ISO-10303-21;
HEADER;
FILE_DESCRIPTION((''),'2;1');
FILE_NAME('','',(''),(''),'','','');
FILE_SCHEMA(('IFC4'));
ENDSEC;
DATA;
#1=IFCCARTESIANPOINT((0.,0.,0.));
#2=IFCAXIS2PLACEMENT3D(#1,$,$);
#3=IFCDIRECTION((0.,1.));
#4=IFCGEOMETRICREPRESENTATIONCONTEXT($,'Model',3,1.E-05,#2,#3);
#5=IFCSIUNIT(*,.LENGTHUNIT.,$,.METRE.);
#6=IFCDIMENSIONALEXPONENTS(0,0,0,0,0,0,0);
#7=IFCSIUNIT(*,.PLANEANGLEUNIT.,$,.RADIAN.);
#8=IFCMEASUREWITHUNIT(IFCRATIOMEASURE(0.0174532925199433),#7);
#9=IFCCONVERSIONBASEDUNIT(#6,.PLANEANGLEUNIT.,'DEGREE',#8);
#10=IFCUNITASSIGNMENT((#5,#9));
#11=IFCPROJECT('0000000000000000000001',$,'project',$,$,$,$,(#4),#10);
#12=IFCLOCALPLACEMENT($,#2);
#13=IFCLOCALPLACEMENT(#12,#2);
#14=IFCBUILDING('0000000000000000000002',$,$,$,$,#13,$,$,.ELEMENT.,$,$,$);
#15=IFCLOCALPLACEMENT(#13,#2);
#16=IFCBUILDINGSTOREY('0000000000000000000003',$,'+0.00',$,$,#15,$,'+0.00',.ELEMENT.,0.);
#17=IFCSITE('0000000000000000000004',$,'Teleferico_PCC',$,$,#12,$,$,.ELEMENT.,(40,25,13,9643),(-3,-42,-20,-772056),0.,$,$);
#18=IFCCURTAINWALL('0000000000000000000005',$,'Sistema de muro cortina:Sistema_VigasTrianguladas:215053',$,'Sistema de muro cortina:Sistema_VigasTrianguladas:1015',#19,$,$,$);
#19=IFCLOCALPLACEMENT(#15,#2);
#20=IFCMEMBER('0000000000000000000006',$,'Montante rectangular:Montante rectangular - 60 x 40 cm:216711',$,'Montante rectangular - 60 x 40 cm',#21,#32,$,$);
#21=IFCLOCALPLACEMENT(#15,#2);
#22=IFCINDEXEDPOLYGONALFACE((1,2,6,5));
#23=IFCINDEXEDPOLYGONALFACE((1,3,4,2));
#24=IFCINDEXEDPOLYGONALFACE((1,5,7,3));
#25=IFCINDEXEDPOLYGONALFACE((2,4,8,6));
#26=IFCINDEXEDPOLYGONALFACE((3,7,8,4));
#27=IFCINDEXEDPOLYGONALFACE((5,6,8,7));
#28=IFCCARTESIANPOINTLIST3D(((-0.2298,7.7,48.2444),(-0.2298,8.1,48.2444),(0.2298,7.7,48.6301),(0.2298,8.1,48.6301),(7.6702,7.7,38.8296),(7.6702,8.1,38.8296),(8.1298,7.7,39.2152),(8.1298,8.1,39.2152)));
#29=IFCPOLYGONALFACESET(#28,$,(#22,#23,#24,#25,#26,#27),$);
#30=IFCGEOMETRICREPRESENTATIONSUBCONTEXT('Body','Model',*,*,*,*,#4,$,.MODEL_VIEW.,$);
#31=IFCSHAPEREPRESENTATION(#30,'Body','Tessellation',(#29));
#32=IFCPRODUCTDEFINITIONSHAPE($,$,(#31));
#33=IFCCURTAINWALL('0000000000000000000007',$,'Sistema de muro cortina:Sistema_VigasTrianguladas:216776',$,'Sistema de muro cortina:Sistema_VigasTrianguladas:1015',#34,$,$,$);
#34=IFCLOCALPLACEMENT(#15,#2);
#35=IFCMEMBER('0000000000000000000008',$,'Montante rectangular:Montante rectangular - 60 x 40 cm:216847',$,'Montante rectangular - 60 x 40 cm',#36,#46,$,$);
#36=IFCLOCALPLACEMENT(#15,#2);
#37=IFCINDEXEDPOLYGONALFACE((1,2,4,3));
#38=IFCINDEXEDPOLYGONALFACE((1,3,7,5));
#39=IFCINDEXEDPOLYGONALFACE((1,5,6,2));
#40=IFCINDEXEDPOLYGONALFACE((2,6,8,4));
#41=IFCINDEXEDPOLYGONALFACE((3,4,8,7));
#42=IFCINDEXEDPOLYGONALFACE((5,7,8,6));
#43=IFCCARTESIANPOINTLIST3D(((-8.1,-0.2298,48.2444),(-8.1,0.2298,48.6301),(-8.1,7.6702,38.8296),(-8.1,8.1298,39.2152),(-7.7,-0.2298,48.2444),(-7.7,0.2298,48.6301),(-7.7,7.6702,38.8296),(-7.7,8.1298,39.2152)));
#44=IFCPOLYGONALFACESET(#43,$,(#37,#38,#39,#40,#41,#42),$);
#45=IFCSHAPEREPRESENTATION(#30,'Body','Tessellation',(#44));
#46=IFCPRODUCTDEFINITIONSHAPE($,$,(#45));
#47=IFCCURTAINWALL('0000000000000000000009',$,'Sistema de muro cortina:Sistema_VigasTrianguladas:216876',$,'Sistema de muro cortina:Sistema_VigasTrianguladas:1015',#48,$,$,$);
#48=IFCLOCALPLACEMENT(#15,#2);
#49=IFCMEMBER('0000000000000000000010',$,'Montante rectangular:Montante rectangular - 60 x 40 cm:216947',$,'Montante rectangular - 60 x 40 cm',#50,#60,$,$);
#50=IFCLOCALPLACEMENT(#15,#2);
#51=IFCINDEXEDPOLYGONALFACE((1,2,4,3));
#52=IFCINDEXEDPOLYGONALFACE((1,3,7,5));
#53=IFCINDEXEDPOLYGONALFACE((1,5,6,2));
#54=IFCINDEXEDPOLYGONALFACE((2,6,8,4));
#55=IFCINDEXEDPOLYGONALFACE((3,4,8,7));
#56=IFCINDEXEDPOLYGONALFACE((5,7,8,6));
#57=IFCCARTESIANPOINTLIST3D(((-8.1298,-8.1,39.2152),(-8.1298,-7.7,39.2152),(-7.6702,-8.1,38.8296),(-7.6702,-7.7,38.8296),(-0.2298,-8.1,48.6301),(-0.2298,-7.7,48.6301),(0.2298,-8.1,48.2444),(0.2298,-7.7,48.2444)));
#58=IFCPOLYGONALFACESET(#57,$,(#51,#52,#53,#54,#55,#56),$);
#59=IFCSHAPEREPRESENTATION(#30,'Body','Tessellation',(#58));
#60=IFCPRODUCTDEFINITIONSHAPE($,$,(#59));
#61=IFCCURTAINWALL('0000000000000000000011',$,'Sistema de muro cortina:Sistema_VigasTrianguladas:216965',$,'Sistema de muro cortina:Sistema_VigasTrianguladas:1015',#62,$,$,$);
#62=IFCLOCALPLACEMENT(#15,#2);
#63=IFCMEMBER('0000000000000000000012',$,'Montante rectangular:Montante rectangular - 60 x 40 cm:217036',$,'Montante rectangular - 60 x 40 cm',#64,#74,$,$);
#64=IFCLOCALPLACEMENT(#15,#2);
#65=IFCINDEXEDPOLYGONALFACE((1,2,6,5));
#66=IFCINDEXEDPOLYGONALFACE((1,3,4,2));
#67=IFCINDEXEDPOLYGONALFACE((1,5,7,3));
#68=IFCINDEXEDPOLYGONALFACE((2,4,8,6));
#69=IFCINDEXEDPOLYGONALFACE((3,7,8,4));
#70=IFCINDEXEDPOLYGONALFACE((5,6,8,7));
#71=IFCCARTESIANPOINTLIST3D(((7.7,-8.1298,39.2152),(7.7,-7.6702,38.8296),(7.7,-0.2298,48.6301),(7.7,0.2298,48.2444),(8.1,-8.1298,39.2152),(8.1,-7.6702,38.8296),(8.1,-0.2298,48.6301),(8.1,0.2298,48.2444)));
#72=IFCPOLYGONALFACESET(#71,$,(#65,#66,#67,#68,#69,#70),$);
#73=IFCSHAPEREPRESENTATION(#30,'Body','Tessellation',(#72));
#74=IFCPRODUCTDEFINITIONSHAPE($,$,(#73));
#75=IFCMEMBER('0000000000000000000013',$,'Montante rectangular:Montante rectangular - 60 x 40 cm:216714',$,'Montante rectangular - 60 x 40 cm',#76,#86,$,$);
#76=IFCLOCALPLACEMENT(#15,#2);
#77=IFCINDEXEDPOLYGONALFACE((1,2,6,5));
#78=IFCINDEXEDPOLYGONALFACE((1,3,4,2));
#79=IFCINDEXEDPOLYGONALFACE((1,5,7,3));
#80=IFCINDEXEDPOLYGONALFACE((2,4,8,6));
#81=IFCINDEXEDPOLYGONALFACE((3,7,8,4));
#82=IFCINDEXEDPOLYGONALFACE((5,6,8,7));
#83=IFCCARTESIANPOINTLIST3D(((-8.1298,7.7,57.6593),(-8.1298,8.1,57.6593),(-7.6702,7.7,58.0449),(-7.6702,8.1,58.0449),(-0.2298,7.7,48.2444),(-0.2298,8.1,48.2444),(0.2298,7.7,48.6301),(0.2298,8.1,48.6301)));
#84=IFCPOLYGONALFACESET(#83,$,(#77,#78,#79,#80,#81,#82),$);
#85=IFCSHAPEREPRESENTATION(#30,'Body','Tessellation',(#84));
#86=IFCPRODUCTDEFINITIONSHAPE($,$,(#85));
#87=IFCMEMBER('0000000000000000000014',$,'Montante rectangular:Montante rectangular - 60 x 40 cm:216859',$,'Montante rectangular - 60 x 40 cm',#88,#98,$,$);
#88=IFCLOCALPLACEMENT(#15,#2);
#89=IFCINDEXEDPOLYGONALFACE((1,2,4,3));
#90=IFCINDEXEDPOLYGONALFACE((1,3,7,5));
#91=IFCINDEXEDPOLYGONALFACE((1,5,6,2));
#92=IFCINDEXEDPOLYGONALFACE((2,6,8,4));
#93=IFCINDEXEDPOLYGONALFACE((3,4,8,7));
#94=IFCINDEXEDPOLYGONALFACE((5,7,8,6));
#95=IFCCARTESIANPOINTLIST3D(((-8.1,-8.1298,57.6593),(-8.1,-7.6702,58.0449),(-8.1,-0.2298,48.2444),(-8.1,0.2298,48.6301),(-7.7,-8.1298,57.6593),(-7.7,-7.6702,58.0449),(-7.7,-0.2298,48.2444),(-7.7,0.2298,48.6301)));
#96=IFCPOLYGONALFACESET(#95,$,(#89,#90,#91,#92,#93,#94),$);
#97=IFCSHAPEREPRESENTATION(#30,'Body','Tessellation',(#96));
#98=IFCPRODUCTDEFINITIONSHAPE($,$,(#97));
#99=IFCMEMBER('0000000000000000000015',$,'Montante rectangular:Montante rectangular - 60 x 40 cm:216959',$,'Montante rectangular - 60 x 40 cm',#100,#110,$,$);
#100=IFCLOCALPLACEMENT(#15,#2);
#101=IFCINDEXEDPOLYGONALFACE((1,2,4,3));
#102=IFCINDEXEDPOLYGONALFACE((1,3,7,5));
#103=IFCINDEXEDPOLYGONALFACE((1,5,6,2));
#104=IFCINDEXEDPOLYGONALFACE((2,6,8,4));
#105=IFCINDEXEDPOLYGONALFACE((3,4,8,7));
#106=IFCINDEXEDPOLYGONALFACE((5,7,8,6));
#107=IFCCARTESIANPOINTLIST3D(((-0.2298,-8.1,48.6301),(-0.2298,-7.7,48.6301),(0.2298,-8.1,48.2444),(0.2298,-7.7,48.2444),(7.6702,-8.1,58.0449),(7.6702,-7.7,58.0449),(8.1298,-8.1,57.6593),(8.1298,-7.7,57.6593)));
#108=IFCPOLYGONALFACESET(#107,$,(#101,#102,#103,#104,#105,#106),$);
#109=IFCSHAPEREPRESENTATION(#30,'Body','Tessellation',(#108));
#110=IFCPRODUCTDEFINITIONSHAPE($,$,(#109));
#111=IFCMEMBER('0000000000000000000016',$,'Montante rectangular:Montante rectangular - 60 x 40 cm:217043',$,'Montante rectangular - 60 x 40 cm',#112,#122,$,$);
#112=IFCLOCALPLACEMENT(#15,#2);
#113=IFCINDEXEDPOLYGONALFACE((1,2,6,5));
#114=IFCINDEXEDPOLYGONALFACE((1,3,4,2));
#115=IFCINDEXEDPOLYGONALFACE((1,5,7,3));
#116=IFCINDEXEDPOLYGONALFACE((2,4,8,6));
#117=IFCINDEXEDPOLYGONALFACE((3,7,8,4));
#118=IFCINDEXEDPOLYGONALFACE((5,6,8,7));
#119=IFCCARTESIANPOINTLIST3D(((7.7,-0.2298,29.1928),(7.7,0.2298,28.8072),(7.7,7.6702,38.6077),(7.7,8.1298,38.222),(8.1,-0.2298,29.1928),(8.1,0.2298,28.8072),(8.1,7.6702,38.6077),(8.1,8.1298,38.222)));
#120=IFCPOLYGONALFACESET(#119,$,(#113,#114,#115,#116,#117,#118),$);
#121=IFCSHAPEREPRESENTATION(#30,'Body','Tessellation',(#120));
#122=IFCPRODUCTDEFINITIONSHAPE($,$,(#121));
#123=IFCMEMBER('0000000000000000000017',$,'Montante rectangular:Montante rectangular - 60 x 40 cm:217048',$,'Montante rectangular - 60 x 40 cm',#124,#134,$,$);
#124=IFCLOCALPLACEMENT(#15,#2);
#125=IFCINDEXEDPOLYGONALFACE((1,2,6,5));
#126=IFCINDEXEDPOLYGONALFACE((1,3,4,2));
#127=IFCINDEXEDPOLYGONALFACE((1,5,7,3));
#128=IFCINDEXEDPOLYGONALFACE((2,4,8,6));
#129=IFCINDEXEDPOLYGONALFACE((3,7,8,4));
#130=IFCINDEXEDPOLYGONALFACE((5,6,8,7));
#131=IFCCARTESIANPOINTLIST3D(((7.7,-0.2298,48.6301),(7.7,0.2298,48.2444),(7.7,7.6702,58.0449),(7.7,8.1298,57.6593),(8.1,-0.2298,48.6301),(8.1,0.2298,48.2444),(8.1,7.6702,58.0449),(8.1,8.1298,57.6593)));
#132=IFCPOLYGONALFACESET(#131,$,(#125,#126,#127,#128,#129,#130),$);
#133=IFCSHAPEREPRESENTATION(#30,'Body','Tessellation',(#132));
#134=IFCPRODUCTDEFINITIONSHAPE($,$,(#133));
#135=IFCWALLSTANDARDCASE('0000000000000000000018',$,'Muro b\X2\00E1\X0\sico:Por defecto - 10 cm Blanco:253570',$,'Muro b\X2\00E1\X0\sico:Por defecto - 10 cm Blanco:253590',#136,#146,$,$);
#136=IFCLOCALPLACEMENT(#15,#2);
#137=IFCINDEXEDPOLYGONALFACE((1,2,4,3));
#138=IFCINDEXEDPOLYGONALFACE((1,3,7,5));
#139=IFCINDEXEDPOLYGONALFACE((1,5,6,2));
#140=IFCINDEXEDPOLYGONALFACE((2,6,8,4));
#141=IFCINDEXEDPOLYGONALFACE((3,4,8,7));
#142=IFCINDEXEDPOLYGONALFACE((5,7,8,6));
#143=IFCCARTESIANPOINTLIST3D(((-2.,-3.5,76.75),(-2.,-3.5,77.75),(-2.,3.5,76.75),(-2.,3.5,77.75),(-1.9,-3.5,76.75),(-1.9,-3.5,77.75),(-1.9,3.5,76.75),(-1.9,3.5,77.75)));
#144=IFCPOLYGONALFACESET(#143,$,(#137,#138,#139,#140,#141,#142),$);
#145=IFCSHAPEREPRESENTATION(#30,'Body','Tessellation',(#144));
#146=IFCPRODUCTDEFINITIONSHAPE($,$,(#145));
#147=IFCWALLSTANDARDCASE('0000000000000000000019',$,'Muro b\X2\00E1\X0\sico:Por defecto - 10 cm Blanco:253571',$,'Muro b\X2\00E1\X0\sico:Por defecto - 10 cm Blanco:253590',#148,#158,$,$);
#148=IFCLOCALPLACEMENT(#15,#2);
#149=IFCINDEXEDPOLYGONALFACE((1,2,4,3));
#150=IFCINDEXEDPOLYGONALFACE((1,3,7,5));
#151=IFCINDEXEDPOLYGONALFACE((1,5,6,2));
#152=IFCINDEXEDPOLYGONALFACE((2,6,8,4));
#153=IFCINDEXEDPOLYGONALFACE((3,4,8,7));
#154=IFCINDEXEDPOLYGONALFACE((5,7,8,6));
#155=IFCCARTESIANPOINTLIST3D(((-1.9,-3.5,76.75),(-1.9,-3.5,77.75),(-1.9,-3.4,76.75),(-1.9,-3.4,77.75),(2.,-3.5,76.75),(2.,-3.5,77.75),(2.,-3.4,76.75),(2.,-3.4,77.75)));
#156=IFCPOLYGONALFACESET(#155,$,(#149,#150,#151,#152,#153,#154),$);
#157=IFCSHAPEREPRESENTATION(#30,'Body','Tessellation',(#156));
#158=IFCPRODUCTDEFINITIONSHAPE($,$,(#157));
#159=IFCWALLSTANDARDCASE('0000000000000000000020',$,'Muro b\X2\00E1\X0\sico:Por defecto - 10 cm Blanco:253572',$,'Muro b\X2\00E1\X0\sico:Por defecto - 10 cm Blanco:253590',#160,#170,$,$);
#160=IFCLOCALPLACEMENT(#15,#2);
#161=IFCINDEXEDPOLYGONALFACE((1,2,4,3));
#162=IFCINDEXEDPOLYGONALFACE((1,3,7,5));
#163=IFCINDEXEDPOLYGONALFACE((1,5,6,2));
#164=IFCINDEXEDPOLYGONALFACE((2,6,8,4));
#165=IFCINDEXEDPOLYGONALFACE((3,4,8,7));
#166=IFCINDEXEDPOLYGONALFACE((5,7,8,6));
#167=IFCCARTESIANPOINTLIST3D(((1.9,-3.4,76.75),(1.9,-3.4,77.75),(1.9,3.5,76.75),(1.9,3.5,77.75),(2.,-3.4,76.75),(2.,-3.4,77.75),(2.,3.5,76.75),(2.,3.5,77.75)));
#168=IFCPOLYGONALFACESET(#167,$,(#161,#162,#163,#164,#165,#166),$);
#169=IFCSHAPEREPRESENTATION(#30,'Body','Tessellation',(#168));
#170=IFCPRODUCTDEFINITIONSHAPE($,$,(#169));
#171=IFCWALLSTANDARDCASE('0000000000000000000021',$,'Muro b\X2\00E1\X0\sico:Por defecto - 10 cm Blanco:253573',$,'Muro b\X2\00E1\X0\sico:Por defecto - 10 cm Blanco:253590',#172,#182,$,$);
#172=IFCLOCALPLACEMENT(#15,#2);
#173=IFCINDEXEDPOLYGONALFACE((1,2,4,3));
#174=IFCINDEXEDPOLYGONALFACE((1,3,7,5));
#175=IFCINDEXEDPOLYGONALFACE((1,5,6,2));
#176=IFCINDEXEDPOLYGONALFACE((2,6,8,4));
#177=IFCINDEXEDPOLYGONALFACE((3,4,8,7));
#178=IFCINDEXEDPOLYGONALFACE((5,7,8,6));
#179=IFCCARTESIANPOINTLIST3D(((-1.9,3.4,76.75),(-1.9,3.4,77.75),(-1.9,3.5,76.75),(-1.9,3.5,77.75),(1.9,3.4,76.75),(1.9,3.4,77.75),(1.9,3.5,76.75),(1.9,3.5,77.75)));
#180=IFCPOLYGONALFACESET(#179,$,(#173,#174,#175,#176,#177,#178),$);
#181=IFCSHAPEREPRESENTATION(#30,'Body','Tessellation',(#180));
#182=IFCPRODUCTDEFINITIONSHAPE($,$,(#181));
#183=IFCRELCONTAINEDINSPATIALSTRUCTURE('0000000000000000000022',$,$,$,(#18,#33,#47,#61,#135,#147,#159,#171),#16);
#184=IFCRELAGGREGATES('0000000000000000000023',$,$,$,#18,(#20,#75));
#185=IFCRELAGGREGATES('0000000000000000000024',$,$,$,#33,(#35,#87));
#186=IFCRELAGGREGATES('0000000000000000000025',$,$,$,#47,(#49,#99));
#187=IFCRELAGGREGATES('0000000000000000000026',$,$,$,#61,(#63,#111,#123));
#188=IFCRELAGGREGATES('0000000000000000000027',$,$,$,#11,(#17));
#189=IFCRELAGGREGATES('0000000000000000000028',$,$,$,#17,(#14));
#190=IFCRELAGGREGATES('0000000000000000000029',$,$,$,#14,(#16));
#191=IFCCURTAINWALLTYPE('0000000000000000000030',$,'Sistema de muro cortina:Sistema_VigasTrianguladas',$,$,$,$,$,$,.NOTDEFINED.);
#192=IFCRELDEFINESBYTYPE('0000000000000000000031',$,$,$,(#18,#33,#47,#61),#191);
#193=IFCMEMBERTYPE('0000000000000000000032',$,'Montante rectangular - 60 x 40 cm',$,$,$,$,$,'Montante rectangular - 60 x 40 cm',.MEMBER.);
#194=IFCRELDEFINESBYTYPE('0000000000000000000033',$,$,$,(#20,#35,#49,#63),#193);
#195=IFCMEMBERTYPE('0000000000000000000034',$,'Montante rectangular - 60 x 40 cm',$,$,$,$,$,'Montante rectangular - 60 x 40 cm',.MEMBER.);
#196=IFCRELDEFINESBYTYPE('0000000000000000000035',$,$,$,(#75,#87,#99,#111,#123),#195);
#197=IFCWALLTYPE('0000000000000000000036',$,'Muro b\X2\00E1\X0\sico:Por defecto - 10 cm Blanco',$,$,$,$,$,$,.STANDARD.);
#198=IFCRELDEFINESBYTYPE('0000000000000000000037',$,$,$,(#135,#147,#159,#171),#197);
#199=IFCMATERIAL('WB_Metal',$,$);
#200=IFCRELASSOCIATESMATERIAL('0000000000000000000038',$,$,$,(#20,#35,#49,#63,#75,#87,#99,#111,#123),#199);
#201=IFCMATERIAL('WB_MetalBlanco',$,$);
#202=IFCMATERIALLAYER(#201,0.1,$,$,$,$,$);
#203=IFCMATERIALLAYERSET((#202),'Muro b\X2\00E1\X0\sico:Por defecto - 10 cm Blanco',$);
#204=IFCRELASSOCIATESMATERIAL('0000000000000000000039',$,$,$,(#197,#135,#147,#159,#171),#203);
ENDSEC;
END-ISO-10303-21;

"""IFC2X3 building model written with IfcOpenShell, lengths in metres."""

from ifc_helpers import new_model, entity, si_unit, converted_unit, direction, frame, frame_2d, origin, origin_2d_with_axis, place, context, subcontext, project, spatial, rectangle, extrude, source, transform, mapped, material, layer, layer_set, layer_usage, type_object, type_shapes, element, aggregate, save


model = new_model("IFC2X3")

# Units and contexts
model_context = context("Model", 3, precision=1e-05, world=origin(), true_north=direction((0.0, 1.0)))
body_context = subcontext(model_context, "Body", "Model", "MODEL_VIEW")
ifc_project = project(units=[si_unit("LENGTHUNIT", "METRE"), converted_unit("PLANEANGLEUNIT", "DEGREE", entity("IfcRatioMeasure", 0.0174532925199433), si_unit("PLANEANGLEUNIT", "RADIAN"), dimensions=[0, 0, 0, 0, 0, 0, 0])], contexts=[model_context])

# Site, building, storey
site_placement = place(None, origin())
site = spatial("IfcSite", under=ifc_project, at=site_placement, Name="Teleferico_PCC", CompositionType="ELEMENT", RefLatitude=(40, 25, 13, 9643), RefLongitude=(-3, -42, -20, -772056), RefElevation=0.0)
building_placement = place(site_placement, origin())
building = spatial("IfcBuilding", under=site, at=building_placement, CompositionType="ELEMENT")
storey_placement = place(building_placement, origin())
storey = spatial("IfcBuildingStorey", under=building, at=storey_placement, Name="+0.00", LongName="+0.00", CompositionType="ELEMENT", Elevation=0.0)

# Curtain walls, members
curtain_wall_type = type_object("IfcCurtainWallType", Name="Sistema de muro cortina:Sistema_VigasTrianguladas", PredefinedType="NOTDEFINED")
curtain_wall_1_placement = place(storey_placement, origin())
curtain_wall_1 = element("IfcCurtainWall", 1, at=curtain_wall_1_placement, inside=storey, type_object=curtain_wall_type, Name="Sistema de muro cortina:Sistema_VigasTrianguladas:215053", ObjectType="Sistema de muro cortina:Sistema_VigasTrianguladas:1015")
ifc_material_1 = material(Name="WB_Metal")
member_type_1 = type_object("IfcMemberType", Name="Montante rectangular - 60 x 40 cm", ElementType="Montante rectangular - 60 x 40 cm", PredefinedType="MEMBER")
shared_shape_1 = source(origin(), body_context, "Body", "SweptSolid", [
    extrude(rectangle(XDim=0.4, YDim=0.6, at=frame_2d((0.0, 0.0), x_axis=(1.0, 0.0))), frame((0.0, 0.0, -12.2902), z_axis=(0.0, 0.0, 1.0), x_axis=(0.0, -1.0, 0.0)), (0.0, 0.0, 1.0), 12.2902),
])
type_shapes(member_type_1, [shared_shape_1])
member_1_placement = place(storey_placement, frame((0.0, 7.9, 48.4372), z_axis=(-0.642788, 0.0, 0.766044), x_axis=(0.766044, 0.0, 0.642788)))
member_1 = element("IfcMember", 2, at=member_1_placement, type_object=member_type_1, material=ifc_material_1, Name="Montante rectangular:Montante rectangular - 60 x 40 cm:216711", ObjectType="Montante rectangular - 60 x 40 cm", context=body_context, shape_type="MappedRepresentation", body=[
    mapped(shared_shape_1, transform((0.0, 0.0, 0.0), scale=1.0)),
])
curtain_wall_2_placement = place(storey_placement, origin())
curtain_wall_2 = element("IfcCurtainWall", 3, at=curtain_wall_2_placement, inside=storey, type_object=curtain_wall_type, Name="Sistema de muro cortina:Sistema_VigasTrianguladas:216776", ObjectType="Sistema de muro cortina:Sistema_VigasTrianguladas:1015")
member_2_placement = place(storey_placement, frame((-7.9, 0.0, 48.4372), z_axis=(0.0, -0.642788, 0.766044), x_axis=(0.0, 0.766044, 0.642788)))
member_2 = element("IfcMember", 4, at=member_2_placement, type_object=member_type_1, material=ifc_material_1, Name="Montante rectangular:Montante rectangular - 60 x 40 cm:216847", ObjectType="Montante rectangular - 60 x 40 cm", context=body_context, shape_type="MappedRepresentation", body=[
    mapped(shared_shape_1, transform((0.0, 0.0, 0.0), scale=1.0)),
])
curtain_wall_3_placement = place(storey_placement, origin())
curtain_wall_3 = element("IfcCurtainWall", 5, at=curtain_wall_3_placement, inside=storey, type_object=curtain_wall_type, Name="Sistema de muro cortina:Sistema_VigasTrianguladas:216876", ObjectType="Sistema de muro cortina:Sistema_VigasTrianguladas:1015")
member_3_placement = place(storey_placement, frame((0.0, -7.9, 48.4372), z_axis=(0.642788, 0.0, 0.766044), x_axis=(-0.766044, 0.0, 0.642788)))
member_3 = element("IfcMember", 6, at=member_3_placement, type_object=member_type_1, material=ifc_material_1, Name="Montante rectangular:Montante rectangular - 60 x 40 cm:216947", ObjectType="Montante rectangular - 60 x 40 cm", context=body_context, shape_type="MappedRepresentation", body=[
    mapped(shared_shape_1, transform((0.0, 0.0, 0.0), scale=1.0)),
])
curtain_wall_4_placement = place(storey_placement, origin())
curtain_wall_4 = element("IfcCurtainWall", 7, at=curtain_wall_4_placement, inside=storey, type_object=curtain_wall_type, Name="Sistema de muro cortina:Sistema_VigasTrianguladas:216965", ObjectType="Sistema de muro cortina:Sistema_VigasTrianguladas:1015")
member_4_placement = place(storey_placement, frame((7.9, 0.0, 48.4372), z_axis=(0.0, 0.642788, 0.766044), x_axis=(0.0, -0.766044, 0.642788)))
member_4 = element("IfcMember", 8, at=member_4_placement, type_object=member_type_1, material=ifc_material_1, Name="Montante rectangular:Montante rectangular - 60 x 40 cm:217036", ObjectType="Montante rectangular - 60 x 40 cm", context=body_context, shape_type="MappedRepresentation", body=[
    mapped(shared_shape_1, transform((0.0, 0.0, 0.0), scale=1.0)),
])

# Members
member_type_2 = type_object("IfcMemberType", Name="Montante rectangular - 60 x 40 cm", ElementType="Montante rectangular - 60 x 40 cm", PredefinedType="MEMBER")
shared_shape_2 = source(origin(), body_context, "Body", "SweptSolid", [
    extrude(rectangle(XDim=0.4, YDim=0.6, at=origin_2d_with_axis()), frame((0.0, 0.0, -12.2902), z_axis=(0.0, 0.0, 1.0), x_axis=(0.0, -1.0, 0.0)), (0.0, 0.0, 1.0), 12.2902),
])
type_shapes(member_type_2, [shared_shape_2])
member_5_placement = place(storey_placement, frame((-7.9, 7.9, 57.8521), z_axis=(-0.642788, 0.0, 0.766044), x_axis=(0.766044, 0.0, 0.642788)))
member_5 = element("IfcMember", 9, at=member_5_placement, type_object=member_type_2, material=ifc_material_1, Name="Montante rectangular:Montante rectangular - 60 x 40 cm:216714", ObjectType="Montante rectangular - 60 x 40 cm", context=body_context, shape_type="MappedRepresentation", body=[
    mapped(shared_shape_2, transform((0.0, 0.0, 0.0), scale=1.0)),
])
member_6_placement = place(storey_placement, frame((-7.9, -7.9, 57.8521), z_axis=(0.0, -0.642788, 0.766044), x_axis=(0.0, 0.766044, 0.642788)))
member_6 = element("IfcMember", 10, at=member_6_placement, type_object=member_type_2, material=ifc_material_1, Name="Montante rectangular:Montante rectangular - 60 x 40 cm:216859", ObjectType="Montante rectangular - 60 x 40 cm", context=body_context, shape_type="MappedRepresentation", body=[
    mapped(shared_shape_2, transform((0.0, 0.0, 0.0), scale=1.0)),
])
member_7_placement = place(storey_placement, frame((7.9, -7.9, 57.8521), z_axis=(0.642788, 0.0, 0.766044), x_axis=(-0.766044, 0.0, 0.642788)))
member_7 = element("IfcMember", 11, at=member_7_placement, type_object=member_type_2, material=ifc_material_1, Name="Montante rectangular:Montante rectangular - 60 x 40 cm:216959", ObjectType="Montante rectangular - 60 x 40 cm", context=body_context, shape_type="MappedRepresentation", body=[
    mapped(shared_shape_2, transform((0.0, 0.0, 0.0), scale=1.0)),
])
member_8_placement = place(storey_placement, frame((7.9, 7.9, 38.4149), z_axis=(0.0, 0.642788, 0.766044), x_axis=(0.0, -0.766044, 0.642788)))
member_8 = element("IfcMember", 12, at=member_8_placement, type_object=member_type_2, material=ifc_material_1, Name="Montante rectangular:Montante rectangular - 60 x 40 cm:217043", ObjectType="Montante rectangular - 60 x 40 cm", context=body_context, shape_type="MappedRepresentation", body=[
    mapped(shared_shape_2, transform((0.0, 0.0, 0.0), scale=1.0)),
])
member_9_placement = place(storey_placement, frame((7.9, 7.9, 57.8521), z_axis=(0.0, 0.642788, 0.766044), x_axis=(0.0, -0.766044, 0.642788)))
member_9 = element("IfcMember", 13, at=member_9_placement, type_object=member_type_2, material=ifc_material_1, Name="Montante rectangular:Montante rectangular - 60 x 40 cm:217048", ObjectType="Montante rectangular - 60 x 40 cm", context=body_context, shape_type="MappedRepresentation", body=[
    mapped(shared_shape_2, transform((0.0, 0.0, 0.0), scale=1.0)),
])
aggregate(curtain_wall_1, [member_1, member_5])
aggregate(curtain_wall_2, [member_2, member_6])
aggregate(curtain_wall_3, [member_3, member_7])
aggregate(curtain_wall_4, [member_4, member_8, member_9])

# Walls
ifc_material_2 = material(Name="WB_MetalBlanco")
ifc_layer = layer(ifc_material_2, 0.1)
ifc_layer_set = layer_set([ifc_layer], Name="Muro básico:Por defecto - 10 cm Blanco")
ifc_layer_usage_1 = layer_usage(ifc_layer_set, "AXIS2", "POSITIVE", -0.05)
wall_type = type_object("IfcWallType", Name="Muro básico:Por defecto - 10 cm Blanco", PredefinedType="STANDARD", material=ifc_layer_set)
wall_1_placement = place(storey_placement, frame((-1.95, 3.5, 76.75), z_axis=(0.0, 0.0, 1.0), x_axis=(0.0, -1.0, 0.0)))
element("IfcWallStandardCase", 14, at=wall_1_placement, inside=storey, type_object=wall_type, material=ifc_layer_usage_1, Name="Muro básico:Por defecto - 10 cm Blanco:253570", ObjectType="Muro básico:Por defecto - 10 cm Blanco:253590", context=body_context, shape_type="SweptSolid", body=[
    extrude(rectangle(XDim=7.0, YDim=0.1, at=frame_2d((3.5, 0.0), x_axis=(-1.0, 0.0))), origin(), (0.0, 0.0, 1.0), 1.0),
])
ifc_layer_usage_2 = layer_usage(ifc_layer_set, "AXIS2", "POSITIVE", -0.05)
wall_2_placement = place(storey_placement, frame((-1.9, -3.45, 76.75)))
element("IfcWallStandardCase", 15, at=wall_2_placement, inside=storey, type_object=wall_type, material=ifc_layer_usage_2, Name="Muro básico:Por defecto - 10 cm Blanco:253571", ObjectType="Muro básico:Por defecto - 10 cm Blanco:253590", context=body_context, shape_type="SweptSolid", body=[
    extrude(rectangle(XDim=3.9, YDim=0.1, at=frame_2d((1.95, 0.0), x_axis=(-1.0, 0.0))), origin(), (0.0, 0.0, 1.0), 1.0),
])
ifc_layer_usage_3 = layer_usage(ifc_layer_set, "AXIS2", "POSITIVE", -0.05)
wall_3_placement = place(storey_placement, frame((1.95, -3.4, 76.75), z_axis=(0.0, 0.0, 1.0), x_axis=(0.0, 1.0, 0.0)))
element("IfcWallStandardCase", 16, at=wall_3_placement, inside=storey, type_object=wall_type, material=ifc_layer_usage_3, Name="Muro básico:Por defecto - 10 cm Blanco:253572", ObjectType="Muro básico:Por defecto - 10 cm Blanco:253590", context=body_context, shape_type="SweptSolid", body=[
    extrude(rectangle(XDim=6.9, YDim=0.1, at=frame_2d((3.45, 0.0), x_axis=(-1.0, 0.0))), origin(), (0.0, 0.0, 1.0), 1.0),
])
ifc_layer_usage_4 = layer_usage(ifc_layer_set, "AXIS2", "POSITIVE", -0.05)
wall_4_placement = place(storey_placement, frame((1.9, 3.45, 76.75), z_axis=(0.0, 0.0, 1.0), x_axis=(-1.0, 0.0, 0.0)))
element("IfcWallStandardCase", 17, at=wall_4_placement, inside=storey, type_object=wall_type, material=ifc_layer_usage_4, Name="Muro básico:Por defecto - 10 cm Blanco:253573", ObjectType="Muro básico:Por defecto - 10 cm Blanco:253590", context=body_context, shape_type="SweptSolid", body=[
    extrude(rectangle(XDim=3.8, YDim=0.1, at=frame_2d((1.9, 0.0), x_axis=(-1.0, 0.0))), origin(), (0.0, 0.0, 1.0), 1.0),
])

save(model, "model.ifc")
